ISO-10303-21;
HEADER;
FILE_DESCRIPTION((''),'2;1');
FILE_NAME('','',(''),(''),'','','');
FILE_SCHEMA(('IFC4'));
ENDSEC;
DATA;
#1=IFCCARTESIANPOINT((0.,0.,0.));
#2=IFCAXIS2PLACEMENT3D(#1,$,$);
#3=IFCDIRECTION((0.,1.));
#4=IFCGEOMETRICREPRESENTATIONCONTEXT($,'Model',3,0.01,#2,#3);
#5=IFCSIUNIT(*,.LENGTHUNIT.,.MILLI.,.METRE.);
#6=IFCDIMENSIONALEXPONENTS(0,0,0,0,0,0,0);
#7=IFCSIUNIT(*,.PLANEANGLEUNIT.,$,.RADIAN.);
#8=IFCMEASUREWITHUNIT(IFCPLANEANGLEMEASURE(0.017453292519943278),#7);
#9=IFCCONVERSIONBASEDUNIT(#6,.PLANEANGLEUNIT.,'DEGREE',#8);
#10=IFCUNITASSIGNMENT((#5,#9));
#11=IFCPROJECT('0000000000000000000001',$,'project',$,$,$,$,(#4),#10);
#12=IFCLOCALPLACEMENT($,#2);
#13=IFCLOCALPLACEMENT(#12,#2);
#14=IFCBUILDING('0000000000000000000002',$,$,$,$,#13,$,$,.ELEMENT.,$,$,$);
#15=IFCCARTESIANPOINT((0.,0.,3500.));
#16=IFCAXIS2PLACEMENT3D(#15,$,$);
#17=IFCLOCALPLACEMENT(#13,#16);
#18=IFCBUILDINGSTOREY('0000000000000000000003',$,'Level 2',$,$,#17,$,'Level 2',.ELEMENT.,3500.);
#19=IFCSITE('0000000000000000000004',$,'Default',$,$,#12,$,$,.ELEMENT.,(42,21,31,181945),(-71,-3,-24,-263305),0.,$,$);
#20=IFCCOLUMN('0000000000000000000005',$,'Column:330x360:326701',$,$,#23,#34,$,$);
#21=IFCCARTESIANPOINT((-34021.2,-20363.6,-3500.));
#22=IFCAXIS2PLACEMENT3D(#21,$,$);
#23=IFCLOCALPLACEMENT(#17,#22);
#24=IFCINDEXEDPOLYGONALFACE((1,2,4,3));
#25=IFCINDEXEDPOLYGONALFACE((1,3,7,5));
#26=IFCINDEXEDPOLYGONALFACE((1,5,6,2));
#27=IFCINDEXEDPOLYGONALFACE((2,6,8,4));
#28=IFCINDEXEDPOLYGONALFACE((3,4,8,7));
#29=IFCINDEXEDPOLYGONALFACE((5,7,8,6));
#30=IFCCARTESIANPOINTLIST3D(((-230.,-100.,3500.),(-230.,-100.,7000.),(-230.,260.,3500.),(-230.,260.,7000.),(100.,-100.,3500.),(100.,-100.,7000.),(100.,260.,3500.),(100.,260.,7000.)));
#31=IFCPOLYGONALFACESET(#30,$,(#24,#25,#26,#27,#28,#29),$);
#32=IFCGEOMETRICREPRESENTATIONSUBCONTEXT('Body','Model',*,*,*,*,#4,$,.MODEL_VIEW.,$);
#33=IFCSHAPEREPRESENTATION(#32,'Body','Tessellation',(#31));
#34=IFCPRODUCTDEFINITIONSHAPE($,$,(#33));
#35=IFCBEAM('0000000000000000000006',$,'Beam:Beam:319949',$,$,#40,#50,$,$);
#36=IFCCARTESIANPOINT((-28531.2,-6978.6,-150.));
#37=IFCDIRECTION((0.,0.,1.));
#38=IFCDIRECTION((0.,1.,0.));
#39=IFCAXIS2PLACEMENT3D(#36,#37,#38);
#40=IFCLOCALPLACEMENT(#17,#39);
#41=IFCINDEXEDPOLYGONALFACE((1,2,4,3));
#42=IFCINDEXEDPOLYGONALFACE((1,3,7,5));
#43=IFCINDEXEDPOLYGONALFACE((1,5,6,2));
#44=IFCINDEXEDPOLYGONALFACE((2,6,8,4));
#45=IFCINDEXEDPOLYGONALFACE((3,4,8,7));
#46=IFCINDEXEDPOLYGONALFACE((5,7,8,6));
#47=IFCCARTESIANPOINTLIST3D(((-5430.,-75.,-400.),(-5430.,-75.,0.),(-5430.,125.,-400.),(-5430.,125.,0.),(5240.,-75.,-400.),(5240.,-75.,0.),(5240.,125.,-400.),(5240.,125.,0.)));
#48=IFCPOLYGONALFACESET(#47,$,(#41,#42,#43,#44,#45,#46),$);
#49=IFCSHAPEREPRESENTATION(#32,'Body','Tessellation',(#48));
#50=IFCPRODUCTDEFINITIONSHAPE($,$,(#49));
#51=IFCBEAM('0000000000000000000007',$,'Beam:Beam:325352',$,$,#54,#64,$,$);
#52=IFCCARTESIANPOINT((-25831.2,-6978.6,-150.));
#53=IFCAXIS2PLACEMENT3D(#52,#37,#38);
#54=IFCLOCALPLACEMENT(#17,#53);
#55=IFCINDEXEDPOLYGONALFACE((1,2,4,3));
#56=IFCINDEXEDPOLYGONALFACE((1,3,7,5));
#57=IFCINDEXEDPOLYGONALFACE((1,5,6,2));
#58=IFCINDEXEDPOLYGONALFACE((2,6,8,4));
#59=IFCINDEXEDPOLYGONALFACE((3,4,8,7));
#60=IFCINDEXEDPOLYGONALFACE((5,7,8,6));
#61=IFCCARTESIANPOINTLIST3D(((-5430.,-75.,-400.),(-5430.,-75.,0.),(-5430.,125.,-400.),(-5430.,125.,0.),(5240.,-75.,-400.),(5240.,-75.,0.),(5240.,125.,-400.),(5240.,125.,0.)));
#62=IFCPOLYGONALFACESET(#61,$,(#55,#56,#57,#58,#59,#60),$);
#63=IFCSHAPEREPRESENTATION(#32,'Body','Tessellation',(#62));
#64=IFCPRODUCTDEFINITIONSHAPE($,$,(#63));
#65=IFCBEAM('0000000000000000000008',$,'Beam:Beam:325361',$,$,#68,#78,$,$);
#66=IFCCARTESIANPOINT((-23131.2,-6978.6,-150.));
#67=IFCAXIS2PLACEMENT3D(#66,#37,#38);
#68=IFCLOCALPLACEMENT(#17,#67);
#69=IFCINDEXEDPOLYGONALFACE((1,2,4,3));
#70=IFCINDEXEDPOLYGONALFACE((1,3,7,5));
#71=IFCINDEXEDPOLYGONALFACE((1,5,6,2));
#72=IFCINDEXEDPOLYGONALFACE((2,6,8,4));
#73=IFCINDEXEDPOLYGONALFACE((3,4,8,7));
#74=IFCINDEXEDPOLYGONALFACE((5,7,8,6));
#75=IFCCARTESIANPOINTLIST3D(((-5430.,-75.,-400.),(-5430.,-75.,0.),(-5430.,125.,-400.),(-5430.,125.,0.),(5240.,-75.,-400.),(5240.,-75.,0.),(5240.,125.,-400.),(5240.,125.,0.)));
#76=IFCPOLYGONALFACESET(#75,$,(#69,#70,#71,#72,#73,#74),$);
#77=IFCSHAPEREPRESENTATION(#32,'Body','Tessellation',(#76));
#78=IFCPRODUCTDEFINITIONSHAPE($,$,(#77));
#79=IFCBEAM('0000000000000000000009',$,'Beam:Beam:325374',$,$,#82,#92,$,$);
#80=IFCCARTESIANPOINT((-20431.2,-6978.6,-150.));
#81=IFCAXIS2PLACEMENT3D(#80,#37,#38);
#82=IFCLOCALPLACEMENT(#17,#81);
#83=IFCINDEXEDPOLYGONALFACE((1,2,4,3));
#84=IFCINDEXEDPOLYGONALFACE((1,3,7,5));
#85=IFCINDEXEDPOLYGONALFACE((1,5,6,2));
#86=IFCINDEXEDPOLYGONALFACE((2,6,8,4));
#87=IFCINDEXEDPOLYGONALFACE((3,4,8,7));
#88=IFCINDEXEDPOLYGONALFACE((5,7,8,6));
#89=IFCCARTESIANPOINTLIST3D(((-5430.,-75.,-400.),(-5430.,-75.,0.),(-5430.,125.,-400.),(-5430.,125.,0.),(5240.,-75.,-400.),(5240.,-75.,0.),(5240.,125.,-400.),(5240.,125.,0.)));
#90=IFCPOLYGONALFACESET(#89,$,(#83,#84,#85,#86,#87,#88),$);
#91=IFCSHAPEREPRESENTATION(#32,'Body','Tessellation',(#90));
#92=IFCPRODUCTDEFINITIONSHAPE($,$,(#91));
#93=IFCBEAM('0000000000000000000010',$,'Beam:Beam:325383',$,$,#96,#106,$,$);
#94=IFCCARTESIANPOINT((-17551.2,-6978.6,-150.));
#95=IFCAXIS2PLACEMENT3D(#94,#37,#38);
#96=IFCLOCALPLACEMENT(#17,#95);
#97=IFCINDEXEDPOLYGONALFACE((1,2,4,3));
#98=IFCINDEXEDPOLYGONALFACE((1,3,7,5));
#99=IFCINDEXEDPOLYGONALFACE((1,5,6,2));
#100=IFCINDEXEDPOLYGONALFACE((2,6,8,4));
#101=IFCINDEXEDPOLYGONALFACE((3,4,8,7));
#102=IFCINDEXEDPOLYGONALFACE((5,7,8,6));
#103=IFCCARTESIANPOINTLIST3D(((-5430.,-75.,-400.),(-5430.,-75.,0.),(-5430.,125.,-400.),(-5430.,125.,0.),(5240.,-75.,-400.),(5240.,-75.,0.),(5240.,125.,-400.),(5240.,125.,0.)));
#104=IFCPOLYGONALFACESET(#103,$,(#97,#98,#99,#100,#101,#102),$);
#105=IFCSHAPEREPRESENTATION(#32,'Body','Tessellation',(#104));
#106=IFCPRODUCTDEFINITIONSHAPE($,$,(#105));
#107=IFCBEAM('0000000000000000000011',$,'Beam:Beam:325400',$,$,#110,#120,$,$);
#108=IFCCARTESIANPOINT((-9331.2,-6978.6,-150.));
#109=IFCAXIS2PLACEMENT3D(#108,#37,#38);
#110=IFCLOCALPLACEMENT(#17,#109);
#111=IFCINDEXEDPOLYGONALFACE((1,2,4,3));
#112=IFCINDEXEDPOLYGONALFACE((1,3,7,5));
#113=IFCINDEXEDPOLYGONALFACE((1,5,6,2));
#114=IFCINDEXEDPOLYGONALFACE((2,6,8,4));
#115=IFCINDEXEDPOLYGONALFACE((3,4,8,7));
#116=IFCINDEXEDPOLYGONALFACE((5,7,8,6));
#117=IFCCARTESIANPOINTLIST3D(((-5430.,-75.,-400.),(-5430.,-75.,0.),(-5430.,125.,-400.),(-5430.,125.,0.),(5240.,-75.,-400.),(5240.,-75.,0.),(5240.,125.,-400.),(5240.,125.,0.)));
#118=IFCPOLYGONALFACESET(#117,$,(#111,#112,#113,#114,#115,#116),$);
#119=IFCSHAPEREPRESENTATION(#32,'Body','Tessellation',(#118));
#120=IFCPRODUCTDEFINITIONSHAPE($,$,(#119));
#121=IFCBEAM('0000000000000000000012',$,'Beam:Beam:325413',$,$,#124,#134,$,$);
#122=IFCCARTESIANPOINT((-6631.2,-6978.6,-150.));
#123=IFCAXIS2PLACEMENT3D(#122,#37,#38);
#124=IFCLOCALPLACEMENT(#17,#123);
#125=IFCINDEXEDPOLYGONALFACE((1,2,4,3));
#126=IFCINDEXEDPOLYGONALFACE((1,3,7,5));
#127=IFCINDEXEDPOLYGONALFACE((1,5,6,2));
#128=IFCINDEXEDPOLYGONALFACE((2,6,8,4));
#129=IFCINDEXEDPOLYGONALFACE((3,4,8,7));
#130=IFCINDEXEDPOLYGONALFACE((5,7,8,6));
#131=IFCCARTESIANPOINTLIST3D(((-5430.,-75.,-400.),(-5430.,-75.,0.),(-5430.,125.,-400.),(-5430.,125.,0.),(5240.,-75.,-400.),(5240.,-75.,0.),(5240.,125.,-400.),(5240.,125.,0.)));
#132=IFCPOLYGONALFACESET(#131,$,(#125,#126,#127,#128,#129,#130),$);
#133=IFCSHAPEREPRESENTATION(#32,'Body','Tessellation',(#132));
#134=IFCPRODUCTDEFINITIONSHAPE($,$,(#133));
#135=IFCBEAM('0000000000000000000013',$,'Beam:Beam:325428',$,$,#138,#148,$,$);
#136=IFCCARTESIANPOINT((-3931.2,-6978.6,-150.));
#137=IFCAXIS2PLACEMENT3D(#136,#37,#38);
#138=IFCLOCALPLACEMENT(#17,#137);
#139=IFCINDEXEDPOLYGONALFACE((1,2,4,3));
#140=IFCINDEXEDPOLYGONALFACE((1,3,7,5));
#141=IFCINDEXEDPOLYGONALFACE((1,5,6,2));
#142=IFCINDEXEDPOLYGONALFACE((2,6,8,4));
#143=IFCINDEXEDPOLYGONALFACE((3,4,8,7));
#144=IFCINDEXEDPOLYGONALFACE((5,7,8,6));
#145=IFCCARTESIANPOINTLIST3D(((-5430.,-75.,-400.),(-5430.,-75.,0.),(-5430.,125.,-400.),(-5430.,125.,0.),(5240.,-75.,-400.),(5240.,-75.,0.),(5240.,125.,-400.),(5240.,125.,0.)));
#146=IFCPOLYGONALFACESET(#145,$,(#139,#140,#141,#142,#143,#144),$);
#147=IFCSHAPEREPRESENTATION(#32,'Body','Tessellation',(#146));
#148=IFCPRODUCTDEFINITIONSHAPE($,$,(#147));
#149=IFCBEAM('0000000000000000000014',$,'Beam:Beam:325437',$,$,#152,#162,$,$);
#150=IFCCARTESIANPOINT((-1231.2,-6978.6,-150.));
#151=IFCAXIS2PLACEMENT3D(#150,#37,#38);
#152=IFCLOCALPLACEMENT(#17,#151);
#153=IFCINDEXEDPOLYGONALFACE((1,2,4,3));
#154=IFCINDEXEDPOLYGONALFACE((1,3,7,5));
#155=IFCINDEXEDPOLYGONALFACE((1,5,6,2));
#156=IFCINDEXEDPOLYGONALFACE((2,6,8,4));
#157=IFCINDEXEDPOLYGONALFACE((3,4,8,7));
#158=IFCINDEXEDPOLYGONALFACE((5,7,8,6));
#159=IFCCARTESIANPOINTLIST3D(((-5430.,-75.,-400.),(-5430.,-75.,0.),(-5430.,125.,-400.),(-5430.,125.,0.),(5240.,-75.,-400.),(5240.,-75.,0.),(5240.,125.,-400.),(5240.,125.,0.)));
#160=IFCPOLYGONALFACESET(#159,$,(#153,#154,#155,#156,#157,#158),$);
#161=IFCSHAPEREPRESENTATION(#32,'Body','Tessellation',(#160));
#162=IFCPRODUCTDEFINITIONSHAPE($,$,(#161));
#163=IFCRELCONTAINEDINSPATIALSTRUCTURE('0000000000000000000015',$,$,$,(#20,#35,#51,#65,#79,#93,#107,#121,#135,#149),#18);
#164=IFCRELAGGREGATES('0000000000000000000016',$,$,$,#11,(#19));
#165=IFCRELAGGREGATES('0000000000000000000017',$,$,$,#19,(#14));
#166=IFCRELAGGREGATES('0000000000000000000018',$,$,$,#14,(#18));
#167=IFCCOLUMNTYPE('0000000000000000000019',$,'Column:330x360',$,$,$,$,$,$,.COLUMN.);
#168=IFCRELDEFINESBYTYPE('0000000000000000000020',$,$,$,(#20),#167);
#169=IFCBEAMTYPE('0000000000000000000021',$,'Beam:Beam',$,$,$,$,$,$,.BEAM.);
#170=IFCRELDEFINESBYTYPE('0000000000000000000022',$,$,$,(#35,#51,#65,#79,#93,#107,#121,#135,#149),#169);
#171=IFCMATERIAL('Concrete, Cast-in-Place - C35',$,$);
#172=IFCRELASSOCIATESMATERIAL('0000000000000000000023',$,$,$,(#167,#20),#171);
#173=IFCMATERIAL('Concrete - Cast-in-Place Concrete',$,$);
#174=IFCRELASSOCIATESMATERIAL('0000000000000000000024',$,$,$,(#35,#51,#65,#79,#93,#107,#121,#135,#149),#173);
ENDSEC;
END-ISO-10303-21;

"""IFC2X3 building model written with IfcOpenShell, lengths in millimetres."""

from ifc_helpers import new_model, entity, si_unit, converted_unit, direction, frame, frame_2d, origin, origin_2d_with_axis, place, context, subcontext, project, spatial, rectangle, extrude, source, transform, mapped, material, type_object, type_shapes, element, save


model = new_model("IFC2X3")

# Units and contexts
model_context = context("Model", 3, precision=0.01, world=origin(), true_north=direction((0.0, 1.0)))
body_context = subcontext(model_context, "Body", "Model", "MODEL_VIEW")
ifc_project = project(units=[si_unit("LENGTHUNIT", "METRE", prefix="MILLI"), converted_unit("PLANEANGLEUNIT", "DEGREE", entity("IfcPlaneAngleMeasure", 0.017453292519943278), si_unit("PLANEANGLEUNIT", "RADIAN"), dimensions=[0, 0, 0, 0, 0, 0, 0])], contexts=[model_context])

# Site, building, storey
site_placement = place(None, origin())
site = spatial("IfcSite", under=ifc_project, at=site_placement, Name="Default", CompositionType="ELEMENT", RefLatitude=(42, 21, 31, 181945), RefLongitude=(-71, -3, -24, -263305), RefElevation=0.0)
building_placement = place(site_placement, origin())
building = spatial("IfcBuilding", under=site, at=building_placement, CompositionType="ELEMENT")
storey_placement = place(building_placement, frame((0.0, 0.0, 3500.0)))
storey = spatial("IfcBuildingStorey", under=building, at=storey_placement, Name="Level 2", LongName="Level 2", CompositionType="ELEMENT", Elevation=3500.0)

# Column
ifc_material_1 = material(Name="Concrete, Cast-in-Place - C35")
column_type_1 = type_object("IfcColumnType", Name="Column:330x360", PredefinedType="COLUMN", material=ifc_material_1)
shared_shape_1 = source(origin(), body_context, "Body", "SweptSolid", [
    extrude(rectangle(XDim=330.0, YDim=360.0, at=origin_2d_with_axis()), frame((-65.0, 80.0, 3500.0), z_axis=(0.0, 0.0, 1.0), x_axis=(-1.0, 0.0, 0.0)), (0.0, 0.0, 1.0), 3500.0),
])
type_shapes(column_type_1, [shared_shape_1])
column_placement = place(storey_placement, frame((-34021.2, -20363.6, -3500.0)))
element("IfcColumn", 1, at=column_placement, inside=storey, type_object=column_type_1, material=ifc_material_1, Name="Column:330x360:326701", context=body_context, shape_type="MappedRepresentation", body=[
    mapped(shared_shape_1, transform((0.0, 0.0, 0.0), scale=1.0)),
])

# Beams
ifc_material_2 = material(Name="Concrete - Cast-in-Place Concrete")
beam_type = type_object("IfcBeamType", Name="Beam:Beam", PredefinedType="BEAM")
beam_1_placement = place(storey_placement, frame((-28531.2, -6978.6, -150.0), z_axis=(0.0, 0.0, 1.0), x_axis=(0.0, 1.0, 0.0)))
element("IfcBeam", 2, at=beam_1_placement, inside=storey, type_object=beam_type, material=ifc_material_2, Name="Beam:Beam:319949", context=body_context, shape_type="SweptSolid", body=[
    extrude(rectangle(XDim=400.0, YDim=200.0, at=frame_2d((0.0, 0.0), x_axis=(1.0, 0.0))), frame((-5430.0, 25.0, -200.0), z_axis=(1.0, 0.0, 0.0), x_axis=(0.0, 0.0, -1.0)), (0.0, 0.0, 1.0), 10670.0),
])
for number, where, z_axis, x_axis, name in (
    (3, (-25831.2, -6978.6, -150.0), (0.0, 0.0, 1.0), (0.0, 1.0, 0.0), "Beam:Beam:325352"),
    (4, (-23131.2, -6978.6, -150.0), (0.0, 0.0, 1.0), (0.0, 1.0, 0.0), "Beam:Beam:325361"),
    (5, (-20431.2, -6978.6, -150.0), (0.0, 0.0, 1.0), (0.0, 1.0, 0.0), "Beam:Beam:325374"),
):
    element("IfcBeam", number, at=place(storey_placement, frame(where, z_axis=z_axis, x_axis=x_axis)), inside=storey, type_object=beam_type, material=ifc_material_2, Name=name, context=body_context, shape_type="SweptSolid", body=[
        extrude(rectangle(XDim=400.0, YDim=200.0, at=frame_2d((0.0, 0.0), x_axis=(1.0, 0.0))), frame((-5430.0, 25.0, -200.0), z_axis=(1.0, 0.0, 0.0), x_axis=(0.0, 0.0, -1.0)), (0.0, 0.0, 1.0), 10670.0),
    ])
beam_2_placement = place(storey_placement, frame((-17551.2, -6978.6, -150.0), z_axis=(0.0, 0.0, 1.0), x_axis=(0.0, 1.0, 0.0)))
element("IfcBeam", 6, at=beam_2_placement, inside=storey, type_object=beam_type, material=ifc_material_2, Name="Beam:Beam:325383", context=body_context, shape_type="SweptSolid", body=[
    extrude(rectangle(XDim=400.0, YDim=200.0, at=frame_2d((0.0, 0.0), x_axis=(1.0, 0.0))), frame((-5430.0, 25.0, -200.0), z_axis=(1.0, 0.0, 0.0), x_axis=(0.0, 0.0, -1.0)), (0.0, 0.0, 1.0), 10670.0),
])
beam_3_placement = place(storey_placement, frame((-9331.2, -6978.6, -150.0), z_axis=(0.0, 0.0, 1.0), x_axis=(0.0, 1.0, 0.0)))
element("IfcBeam", 7, at=beam_3_placement, inside=storey, type_object=beam_type, material=ifc_material_2, Name="Beam:Beam:325400", context=body_context, shape_type="SweptSolid", body=[
    extrude(rectangle(XDim=400.0, YDim=200.0, at=frame_2d((0.0, 0.0), x_axis=(1.0, 0.0))), frame((-5430.0, 25.0, -200.0), z_axis=(1.0, 0.0, 0.0), x_axis=(0.0, 0.0, -1.0)), (0.0, 0.0, 1.0), 10670.0),
])
beam_4_placement = place(storey_placement, frame((-6631.2, -6978.6, -150.0), z_axis=(0.0, 0.0, 1.0), x_axis=(0.0, 1.0, 0.0)))
element("IfcBeam", 8, at=beam_4_placement, inside=storey, type_object=beam_type, material=ifc_material_2, Name="Beam:Beam:325413", context=body_context, shape_type="SweptSolid", body=[
    extrude(rectangle(XDim=400.0, YDim=200.0, at=frame_2d((0.0, 0.0), x_axis=(1.0, 0.0))), frame((-5430.0, 25.0, -200.0), z_axis=(1.0, 0.0, 0.0), x_axis=(0.0, 0.0, -1.0)), (0.0, 0.0, 1.0), 10670.0),
])
beam_5_placement = place(storey_placement, frame((-3931.2, -6978.6, -150.0), z_axis=(0.0, 0.0, 1.0), x_axis=(0.0, 1.0, 0.0)))
element("IfcBeam", 9, at=beam_5_placement, inside=storey, type_object=beam_type, material=ifc_material_2, Name="Beam:Beam:325428", context=body_context, shape_type="SweptSolid", body=[
    extrude(rectangle(XDim=400.0, YDim=200.0, at=frame_2d((0.0, 0.0), x_axis=(1.0, 0.0))), frame((-5430.0, 25.0, -200.0), z_axis=(1.0, 0.0, 0.0), x_axis=(0.0, 0.0, -1.0)), (0.0, 0.0, 1.0), 10670.0),
])
beam_6_placement = place(storey_placement, frame((-1231.2, -6978.6, -150.0), z_axis=(0.0, 0.0, 1.0), x_axis=(0.0, 1.0, 0.0)))
element("IfcBeam", 10, at=beam_6_placement, inside=storey, type_object=beam_type, material=ifc_material_2, Name="Beam:Beam:325437", context=body_context, shape_type="SweptSolid", body=[
    extrude(rectangle(XDim=400.0, YDim=200.0, at=frame_2d((0.0, 0.0), x_axis=(1.0, 0.0))), frame((-5430.0, 25.0, -200.0), z_axis=(1.0, 0.0, 0.0), x_axis=(0.0, 0.0, -1.0)), (0.0, 0.0, 1.0), 10670.0),
])

save(model, "model.ifc")
